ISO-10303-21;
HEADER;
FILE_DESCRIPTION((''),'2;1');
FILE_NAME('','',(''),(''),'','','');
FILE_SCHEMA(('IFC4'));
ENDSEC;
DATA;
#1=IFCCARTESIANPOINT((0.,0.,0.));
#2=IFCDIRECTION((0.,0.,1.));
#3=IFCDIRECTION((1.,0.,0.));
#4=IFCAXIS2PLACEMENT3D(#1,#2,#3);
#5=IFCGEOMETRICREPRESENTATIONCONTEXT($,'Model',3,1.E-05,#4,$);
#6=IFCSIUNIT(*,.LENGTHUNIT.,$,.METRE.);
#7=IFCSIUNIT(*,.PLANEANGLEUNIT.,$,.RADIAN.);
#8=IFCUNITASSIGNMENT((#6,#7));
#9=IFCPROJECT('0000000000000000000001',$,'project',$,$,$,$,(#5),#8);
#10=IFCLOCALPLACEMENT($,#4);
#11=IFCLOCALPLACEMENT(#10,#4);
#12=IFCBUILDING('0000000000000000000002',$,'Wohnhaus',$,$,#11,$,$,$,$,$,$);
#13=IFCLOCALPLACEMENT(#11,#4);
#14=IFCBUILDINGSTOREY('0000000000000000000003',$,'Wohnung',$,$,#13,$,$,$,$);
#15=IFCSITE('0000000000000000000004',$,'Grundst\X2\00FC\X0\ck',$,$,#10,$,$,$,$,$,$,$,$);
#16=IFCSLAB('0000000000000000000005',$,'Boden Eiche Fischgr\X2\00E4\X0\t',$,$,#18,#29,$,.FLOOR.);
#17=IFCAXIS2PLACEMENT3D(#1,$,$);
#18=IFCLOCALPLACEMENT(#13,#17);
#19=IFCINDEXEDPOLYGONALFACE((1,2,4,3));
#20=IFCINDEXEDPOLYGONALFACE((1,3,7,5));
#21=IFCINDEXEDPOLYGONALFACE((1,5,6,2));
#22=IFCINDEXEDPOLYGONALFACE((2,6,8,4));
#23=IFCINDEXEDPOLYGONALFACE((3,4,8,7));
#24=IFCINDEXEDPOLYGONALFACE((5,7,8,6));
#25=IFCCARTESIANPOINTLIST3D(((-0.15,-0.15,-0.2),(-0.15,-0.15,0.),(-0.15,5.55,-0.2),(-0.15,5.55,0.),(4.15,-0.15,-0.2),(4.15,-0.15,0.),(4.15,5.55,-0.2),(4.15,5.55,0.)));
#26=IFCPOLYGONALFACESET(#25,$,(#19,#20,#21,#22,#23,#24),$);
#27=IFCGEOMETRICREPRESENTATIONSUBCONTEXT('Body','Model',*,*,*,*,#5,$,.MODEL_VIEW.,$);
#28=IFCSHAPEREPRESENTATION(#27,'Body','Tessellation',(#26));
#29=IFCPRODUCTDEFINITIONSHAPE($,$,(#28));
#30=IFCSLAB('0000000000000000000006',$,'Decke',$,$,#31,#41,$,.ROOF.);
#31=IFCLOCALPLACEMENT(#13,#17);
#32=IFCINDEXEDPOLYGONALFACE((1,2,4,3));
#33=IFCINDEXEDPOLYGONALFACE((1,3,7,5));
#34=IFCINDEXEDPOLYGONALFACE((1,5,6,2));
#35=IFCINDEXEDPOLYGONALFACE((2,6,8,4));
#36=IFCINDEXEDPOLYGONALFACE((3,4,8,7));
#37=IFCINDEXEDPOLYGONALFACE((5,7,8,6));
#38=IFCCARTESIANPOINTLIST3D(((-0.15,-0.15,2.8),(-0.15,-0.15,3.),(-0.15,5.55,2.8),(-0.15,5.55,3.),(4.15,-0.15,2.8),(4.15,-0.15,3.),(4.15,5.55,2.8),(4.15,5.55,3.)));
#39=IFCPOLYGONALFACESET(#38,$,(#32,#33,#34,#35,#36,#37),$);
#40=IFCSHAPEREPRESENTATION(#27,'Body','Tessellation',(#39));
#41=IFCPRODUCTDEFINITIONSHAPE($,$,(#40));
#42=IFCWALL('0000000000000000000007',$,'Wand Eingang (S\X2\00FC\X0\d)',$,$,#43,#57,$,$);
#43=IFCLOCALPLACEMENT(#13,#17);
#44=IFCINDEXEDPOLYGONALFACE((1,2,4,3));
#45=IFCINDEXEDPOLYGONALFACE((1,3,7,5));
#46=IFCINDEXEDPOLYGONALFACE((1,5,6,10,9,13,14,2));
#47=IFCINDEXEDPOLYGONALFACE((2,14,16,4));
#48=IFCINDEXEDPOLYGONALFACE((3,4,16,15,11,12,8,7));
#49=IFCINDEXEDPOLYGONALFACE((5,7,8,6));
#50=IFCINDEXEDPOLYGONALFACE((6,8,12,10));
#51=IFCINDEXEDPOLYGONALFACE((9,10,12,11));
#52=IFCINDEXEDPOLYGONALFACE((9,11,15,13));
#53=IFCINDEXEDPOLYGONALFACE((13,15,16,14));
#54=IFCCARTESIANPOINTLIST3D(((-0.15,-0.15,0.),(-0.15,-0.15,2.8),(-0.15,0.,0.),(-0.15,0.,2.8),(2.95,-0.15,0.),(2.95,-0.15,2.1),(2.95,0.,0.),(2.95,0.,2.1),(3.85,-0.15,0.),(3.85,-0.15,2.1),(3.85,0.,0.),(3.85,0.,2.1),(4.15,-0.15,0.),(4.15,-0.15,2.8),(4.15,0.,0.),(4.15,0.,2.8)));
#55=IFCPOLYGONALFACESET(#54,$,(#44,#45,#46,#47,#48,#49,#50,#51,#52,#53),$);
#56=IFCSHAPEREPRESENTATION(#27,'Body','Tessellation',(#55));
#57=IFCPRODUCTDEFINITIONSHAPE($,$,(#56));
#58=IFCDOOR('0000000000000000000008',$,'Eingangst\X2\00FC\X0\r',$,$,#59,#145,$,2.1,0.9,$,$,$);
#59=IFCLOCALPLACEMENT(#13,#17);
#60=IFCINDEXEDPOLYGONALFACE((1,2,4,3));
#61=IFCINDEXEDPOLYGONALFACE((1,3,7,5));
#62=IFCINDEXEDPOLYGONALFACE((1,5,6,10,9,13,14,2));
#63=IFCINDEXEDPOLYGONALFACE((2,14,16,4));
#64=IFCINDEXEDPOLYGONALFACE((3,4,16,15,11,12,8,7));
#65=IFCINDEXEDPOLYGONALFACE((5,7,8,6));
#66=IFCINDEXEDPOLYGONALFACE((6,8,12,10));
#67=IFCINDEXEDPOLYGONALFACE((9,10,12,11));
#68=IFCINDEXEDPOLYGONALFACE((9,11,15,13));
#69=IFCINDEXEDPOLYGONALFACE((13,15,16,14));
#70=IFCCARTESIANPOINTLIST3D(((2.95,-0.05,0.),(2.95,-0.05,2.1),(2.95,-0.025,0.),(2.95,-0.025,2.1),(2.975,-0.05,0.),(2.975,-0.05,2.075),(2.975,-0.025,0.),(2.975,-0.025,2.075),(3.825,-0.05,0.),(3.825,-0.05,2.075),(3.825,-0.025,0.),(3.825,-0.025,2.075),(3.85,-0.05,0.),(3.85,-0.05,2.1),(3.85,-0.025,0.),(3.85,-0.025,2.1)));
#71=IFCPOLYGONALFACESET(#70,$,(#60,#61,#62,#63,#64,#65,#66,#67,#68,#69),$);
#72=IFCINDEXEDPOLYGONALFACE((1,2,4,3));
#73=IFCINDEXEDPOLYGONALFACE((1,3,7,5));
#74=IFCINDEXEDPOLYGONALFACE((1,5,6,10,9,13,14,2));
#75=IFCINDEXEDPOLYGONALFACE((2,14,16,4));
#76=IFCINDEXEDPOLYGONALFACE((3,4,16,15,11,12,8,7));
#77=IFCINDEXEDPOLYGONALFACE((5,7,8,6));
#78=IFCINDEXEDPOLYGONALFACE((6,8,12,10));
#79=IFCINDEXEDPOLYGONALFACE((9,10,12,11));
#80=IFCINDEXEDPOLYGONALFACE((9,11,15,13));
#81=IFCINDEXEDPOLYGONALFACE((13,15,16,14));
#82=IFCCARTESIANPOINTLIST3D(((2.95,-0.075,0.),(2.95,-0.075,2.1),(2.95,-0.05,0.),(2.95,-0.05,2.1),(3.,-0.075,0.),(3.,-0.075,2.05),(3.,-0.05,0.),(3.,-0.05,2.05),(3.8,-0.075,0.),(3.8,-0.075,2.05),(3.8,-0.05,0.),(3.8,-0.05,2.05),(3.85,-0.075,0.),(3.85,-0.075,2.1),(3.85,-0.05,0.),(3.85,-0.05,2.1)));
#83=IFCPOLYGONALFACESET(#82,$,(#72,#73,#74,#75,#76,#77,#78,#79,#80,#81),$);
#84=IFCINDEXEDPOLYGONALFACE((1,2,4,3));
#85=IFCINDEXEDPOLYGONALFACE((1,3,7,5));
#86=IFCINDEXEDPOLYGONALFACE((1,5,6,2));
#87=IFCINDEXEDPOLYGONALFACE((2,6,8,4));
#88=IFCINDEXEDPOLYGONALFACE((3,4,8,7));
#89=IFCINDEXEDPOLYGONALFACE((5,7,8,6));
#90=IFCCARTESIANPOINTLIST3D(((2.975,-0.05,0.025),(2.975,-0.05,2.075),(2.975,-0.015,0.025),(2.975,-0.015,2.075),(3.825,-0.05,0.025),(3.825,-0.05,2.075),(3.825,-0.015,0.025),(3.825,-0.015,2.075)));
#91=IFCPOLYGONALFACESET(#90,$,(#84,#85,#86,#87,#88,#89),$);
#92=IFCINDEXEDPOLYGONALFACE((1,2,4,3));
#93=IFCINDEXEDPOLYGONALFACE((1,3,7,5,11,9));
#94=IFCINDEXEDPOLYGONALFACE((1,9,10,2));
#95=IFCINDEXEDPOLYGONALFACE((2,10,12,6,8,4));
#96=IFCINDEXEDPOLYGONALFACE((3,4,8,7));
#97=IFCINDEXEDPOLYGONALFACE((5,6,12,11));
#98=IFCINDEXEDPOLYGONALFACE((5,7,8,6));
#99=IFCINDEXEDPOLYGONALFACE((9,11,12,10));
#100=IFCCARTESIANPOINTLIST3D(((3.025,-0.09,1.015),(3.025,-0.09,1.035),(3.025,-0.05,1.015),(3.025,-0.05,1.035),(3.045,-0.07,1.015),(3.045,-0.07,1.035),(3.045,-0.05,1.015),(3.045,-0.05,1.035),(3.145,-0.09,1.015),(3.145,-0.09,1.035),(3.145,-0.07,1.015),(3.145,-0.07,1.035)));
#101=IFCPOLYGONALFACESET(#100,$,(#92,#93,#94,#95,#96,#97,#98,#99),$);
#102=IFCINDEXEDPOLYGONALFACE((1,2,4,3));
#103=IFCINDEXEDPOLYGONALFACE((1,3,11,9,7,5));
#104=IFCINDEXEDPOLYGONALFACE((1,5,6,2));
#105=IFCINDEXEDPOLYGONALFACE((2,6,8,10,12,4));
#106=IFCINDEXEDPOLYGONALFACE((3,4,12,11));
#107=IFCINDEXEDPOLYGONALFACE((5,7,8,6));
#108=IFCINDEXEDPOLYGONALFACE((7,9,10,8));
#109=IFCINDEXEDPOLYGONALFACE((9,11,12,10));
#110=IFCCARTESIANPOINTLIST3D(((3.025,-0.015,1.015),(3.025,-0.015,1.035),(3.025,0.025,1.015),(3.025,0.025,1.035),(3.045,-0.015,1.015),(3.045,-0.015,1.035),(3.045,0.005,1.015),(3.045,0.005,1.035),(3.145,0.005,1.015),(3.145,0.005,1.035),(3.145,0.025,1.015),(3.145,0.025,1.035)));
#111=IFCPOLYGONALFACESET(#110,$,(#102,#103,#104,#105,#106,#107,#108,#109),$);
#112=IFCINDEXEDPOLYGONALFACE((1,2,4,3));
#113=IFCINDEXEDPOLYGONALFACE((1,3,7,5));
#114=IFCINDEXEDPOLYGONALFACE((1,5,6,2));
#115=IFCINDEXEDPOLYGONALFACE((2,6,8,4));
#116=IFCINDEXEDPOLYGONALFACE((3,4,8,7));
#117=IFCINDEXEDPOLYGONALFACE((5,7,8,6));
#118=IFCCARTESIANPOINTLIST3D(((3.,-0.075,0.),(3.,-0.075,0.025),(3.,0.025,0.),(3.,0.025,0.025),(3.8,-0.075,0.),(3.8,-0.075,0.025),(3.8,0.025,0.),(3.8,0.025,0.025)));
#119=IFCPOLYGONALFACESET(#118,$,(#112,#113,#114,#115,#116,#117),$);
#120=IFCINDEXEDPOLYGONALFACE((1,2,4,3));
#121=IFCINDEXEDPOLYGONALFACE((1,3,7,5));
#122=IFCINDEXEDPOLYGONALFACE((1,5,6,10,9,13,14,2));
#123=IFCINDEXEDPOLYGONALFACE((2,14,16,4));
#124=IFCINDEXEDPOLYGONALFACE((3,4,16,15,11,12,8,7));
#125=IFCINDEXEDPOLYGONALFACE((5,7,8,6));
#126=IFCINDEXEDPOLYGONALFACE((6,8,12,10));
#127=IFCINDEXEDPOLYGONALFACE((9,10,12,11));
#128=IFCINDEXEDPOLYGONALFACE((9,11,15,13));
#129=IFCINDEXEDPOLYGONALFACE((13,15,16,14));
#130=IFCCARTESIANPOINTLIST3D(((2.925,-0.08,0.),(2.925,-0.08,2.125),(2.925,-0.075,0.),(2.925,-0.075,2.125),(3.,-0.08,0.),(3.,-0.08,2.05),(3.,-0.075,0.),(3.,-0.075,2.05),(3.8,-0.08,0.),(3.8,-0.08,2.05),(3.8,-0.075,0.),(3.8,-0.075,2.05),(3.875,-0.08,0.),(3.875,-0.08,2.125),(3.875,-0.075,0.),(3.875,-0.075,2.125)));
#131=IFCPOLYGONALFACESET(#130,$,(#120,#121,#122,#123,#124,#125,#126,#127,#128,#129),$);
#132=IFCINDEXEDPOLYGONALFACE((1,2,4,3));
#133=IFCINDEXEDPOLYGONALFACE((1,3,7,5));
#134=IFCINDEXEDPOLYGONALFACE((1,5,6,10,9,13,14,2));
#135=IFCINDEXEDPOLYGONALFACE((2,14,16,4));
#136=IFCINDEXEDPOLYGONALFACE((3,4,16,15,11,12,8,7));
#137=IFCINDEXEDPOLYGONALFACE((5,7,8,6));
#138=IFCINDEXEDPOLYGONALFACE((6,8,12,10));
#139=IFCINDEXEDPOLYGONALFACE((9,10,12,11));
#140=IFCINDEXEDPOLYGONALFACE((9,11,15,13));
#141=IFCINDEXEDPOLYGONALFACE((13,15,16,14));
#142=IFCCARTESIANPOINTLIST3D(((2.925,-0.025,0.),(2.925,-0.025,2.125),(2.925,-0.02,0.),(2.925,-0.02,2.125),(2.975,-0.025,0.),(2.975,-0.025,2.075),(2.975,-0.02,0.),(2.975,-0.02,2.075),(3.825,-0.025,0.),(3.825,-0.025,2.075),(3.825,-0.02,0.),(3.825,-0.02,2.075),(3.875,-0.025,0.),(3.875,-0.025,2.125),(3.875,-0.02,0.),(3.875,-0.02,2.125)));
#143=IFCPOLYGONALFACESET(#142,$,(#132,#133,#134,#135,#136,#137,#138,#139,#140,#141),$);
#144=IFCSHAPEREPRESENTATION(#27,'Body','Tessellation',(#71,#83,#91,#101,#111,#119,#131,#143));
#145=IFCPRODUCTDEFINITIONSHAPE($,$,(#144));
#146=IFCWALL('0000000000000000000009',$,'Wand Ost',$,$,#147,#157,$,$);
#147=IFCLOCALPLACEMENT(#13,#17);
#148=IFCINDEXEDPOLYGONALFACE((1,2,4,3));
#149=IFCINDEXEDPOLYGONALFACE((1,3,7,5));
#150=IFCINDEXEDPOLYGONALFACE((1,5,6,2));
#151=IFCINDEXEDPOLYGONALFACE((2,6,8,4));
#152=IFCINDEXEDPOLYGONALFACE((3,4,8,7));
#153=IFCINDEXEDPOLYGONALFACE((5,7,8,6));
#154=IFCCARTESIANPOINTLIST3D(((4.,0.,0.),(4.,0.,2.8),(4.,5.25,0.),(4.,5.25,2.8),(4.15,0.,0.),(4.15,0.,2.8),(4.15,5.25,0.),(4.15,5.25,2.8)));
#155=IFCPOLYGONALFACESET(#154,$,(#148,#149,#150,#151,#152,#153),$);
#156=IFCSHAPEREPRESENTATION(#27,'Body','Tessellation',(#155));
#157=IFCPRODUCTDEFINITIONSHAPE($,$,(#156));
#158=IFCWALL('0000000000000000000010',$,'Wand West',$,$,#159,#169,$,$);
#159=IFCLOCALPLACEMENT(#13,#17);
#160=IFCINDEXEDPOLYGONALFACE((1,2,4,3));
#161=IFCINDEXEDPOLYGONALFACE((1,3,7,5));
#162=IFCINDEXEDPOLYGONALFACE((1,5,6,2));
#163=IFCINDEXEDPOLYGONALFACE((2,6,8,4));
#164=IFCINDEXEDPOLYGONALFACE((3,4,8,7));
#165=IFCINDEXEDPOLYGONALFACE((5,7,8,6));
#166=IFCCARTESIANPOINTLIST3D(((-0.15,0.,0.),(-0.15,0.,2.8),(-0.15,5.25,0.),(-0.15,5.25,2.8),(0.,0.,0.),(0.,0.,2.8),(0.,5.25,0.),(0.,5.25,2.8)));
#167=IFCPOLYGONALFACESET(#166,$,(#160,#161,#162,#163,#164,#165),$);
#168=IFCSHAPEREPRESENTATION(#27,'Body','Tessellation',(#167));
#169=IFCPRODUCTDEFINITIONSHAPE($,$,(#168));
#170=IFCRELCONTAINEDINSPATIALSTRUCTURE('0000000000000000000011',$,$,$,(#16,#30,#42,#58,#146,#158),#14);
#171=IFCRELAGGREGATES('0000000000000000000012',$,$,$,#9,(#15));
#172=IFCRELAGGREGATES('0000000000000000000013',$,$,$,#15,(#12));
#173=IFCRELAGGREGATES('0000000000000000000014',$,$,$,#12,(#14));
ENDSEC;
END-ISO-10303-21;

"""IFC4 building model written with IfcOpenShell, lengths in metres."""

from ifc_helpers import new_model, si_unit, frame, origin_with_axes, place, context, subcontext, project, spatial, line, indexed_curve, outline, extrude, element, fill, save


model = new_model("IFC4")

# Units and contexts
model_context = context("Model", 3, precision=1e-05, world=origin_with_axes())
body_context = subcontext(model_context, "Body", "Model", "MODEL_VIEW")
ifc_project = project(units=[si_unit("LENGTHUNIT", "METRE"), si_unit("PLANEANGLEUNIT", "RADIAN")], contexts=[model_context])

# Site, building, storey
site_placement = place(None, origin_with_axes())
site = spatial("IfcSite", under=ifc_project, at=site_placement, Name="Grundstück")
building_placement = place(site_placement, origin_with_axes())
building = spatial("IfcBuilding", under=site, at=building_placement, Name="Wohnhaus")
storey_placement = place(building_placement, origin_with_axes())
storey = spatial("IfcBuildingStorey", under=building, at=storey_placement, Name="Wohnung")

# Slabs
slab_1_placement = place(storey_placement, frame((0.0, 0.0, -0.2), z_axis=(0.0, 0.0, 1.0), x_axis=(1.0, 0.0, 0.0)))
element("IfcSlab", 1, at=slab_1_placement, inside=storey, Name="Boden Eiche Fischgrät", PredefinedType="FLOOR", context=body_context, shape_type="SweptSolid", body=[
    extrude(outline(indexed_curve([(-0.15, -0.15), (4.15, -0.15), (4.15, 5.55), (-0.15, 5.55)])), None, (0.0, 0.0, 1.0), 0.2),
])
slab_2_placement = place(storey_placement, frame((0.0, 0.0, 2.8), z_axis=(0.0, 0.0, 1.0), x_axis=(1.0, 0.0, 0.0)))
element("IfcSlab", 2, at=slab_2_placement, inside=storey, Name="Decke", PredefinedType="ROOF", context=body_context, shape_type="SweptSolid", body=[
    extrude(outline(indexed_curve([(-0.15, -0.15), (4.15, -0.15), (4.15, 5.55), (-0.15, 5.55)])), None, (0.0, 0.0, 1.0), 0.2),
])

# Wall, opening, door
wall_1_placement = place(storey_placement, frame((-0.15, -0.15, 0.0), z_axis=(0.0, 0.0, 1.0), x_axis=(1.0, 0.0, 0.0)))
wall_1 = element("IfcWall", 3, at=wall_1_placement, inside=storey, Name="Wand Eingang (Süd)", context=body_context, shape_type="SweptSolid", body=[
    extrude(outline(indexed_curve([(0.0, 0.0), (0.0, 0.15), (4.3, 0.15), (4.3, 0.0), (0.0, 0.0)], self_intersect=False)), origin_with_axes(), (0.0, 0.0, 1.0), 2.8),
])
opening_1_placement = place(wall_1_placement, frame((3.1, -0.1, 0.0), z_axis=(0.0, 0.0, 1.0), x_axis=(1.0, 0.0, 0.0)))
opening_1 = element("IfcOpeningElement", 4, at=opening_1_placement, cuts=wall_1, context=body_context, shape_type="SweptSolid", body=[
    extrude(outline(indexed_curve([(0.0, 0.0), (0.0, 0.35), (0.9, 0.35), (0.9, 0.0), (0.0, 0.0)], self_intersect=False)), origin_with_axes(), (0.0, 0.0, 1.0), 2.1),
])
door_placement = place(storey_placement, frame((2.95, -0.075, 0.0), z_axis=(0.0, 0.0, 1.0), x_axis=(1.0, 0.0, 0.0)))
door = element("IfcDoor", 5, at=door_placement, inside=storey, Name="Eingangstür", OverallHeight=2.1, OverallWidth=0.9, context=body_context, shape_type="SweptSolid", body=[
    extrude(outline(indexed_curve([(0.0, 0.0), (0.0, 2.1), (0.9, 2.1), (0.9, 0.0), (0.875, 0.0), (0.875, 2.075), (0.025, 2.075), (0.025, 0.0)], segments=[line(1, 2, 3, 4, 5, 6, 7, 8, 1)])), frame((0.0, 0.025, 0.0), z_axis=(0.0, -1.0, 0.0), x_axis=(1.0, 0.0, 0.0)), (0.0, 0.0, -1.0), 0.025),
    extrude(outline(indexed_curve([(0.0, 0.0), (0.0, 2.1), (0.9, 2.1), (0.9, 0.0), (0.85, 0.0), (0.85, 2.05), (0.05, 2.05), (0.05, 0.0)], segments=[line(1, 2, 3, 4, 5, 6, 7, 8, 1)])), frame((0.0, 0.0, 0.0), z_axis=(0.0, -1.0, 0.0), x_axis=(1.0, 0.0, 0.0)), (0.0, 0.0, -1.0), 0.025),
    extrude(outline(indexed_curve([(0.0, 0.0), (0.85, 0.0), (0.85, 0.035), (0.0, 0.035)], segments=[line(1, 2, 3, 4, 1)])), frame((0.025, 0.025, 0.025), z_axis=(0.0, 0.0, 1.0), x_axis=(1.0, 0.0, 0.0)), (0.0, 0.0, 1.0), 2.05),
    extrude(outline(indexed_curve([(0.0, 0.0), (0.0, -0.04), (0.12, -0.04), (0.12, -0.02), (0.02, -0.02), (0.02, 0.0)], segments=[line(1, 2, 3, 4, 5, 6, 1)])), frame((0.075, 0.025, 1.015), z_axis=(0.0, 0.0, 1.0), x_axis=(1.0, 0.0, 0.0)), (0.0, 0.0, 1.0), 0.02),
    extrude(outline(indexed_curve([(0.0, 0.0), (0.0, 0.04), (0.12, 0.04), (0.12, 0.02), (0.02, 0.02), (0.02, 0.0)], segments=[line(1, 2, 3, 4, 5, 6, 1)])), frame((0.075, 0.06, 1.015), z_axis=(0.0, 0.0, 1.0), x_axis=(1.0, 0.0, 0.0)), (0.0, 0.0, 1.0), 0.02),
    extrude(outline(indexed_curve([(0.0, 0.0), (0.8, 0.0), (0.8, 0.1), (0.0, 0.1)], segments=[line(1, 2, 3, 4, 1)])), frame((0.05, 0.0, 0.0), z_axis=(0.0, 0.0, 1.0), x_axis=(1.0, 0.0, 0.0)), (0.0, 0.0, 1.0), 0.025),
    extrude(outline(indexed_curve([(0.0, 0.0), (0.0, 2.125), (0.95, 2.125), (0.95, 0.0), (0.875, 0.0), (0.875, 2.05), (0.075, 2.05), (0.075, 0.0)], segments=[line(1, 2, 3, 4, 5, 6, 7, 8, 1)])), frame((-0.025, -0.005, 0.0), z_axis=(0.0, -1.0, 0.0), x_axis=(1.0, 0.0, 0.0)), (0.0, 0.0, -1.0), 0.005),
    extrude(outline(indexed_curve([(0.0, 0.0), (0.0, 2.125), (0.95, 2.125), (0.95, 0.0), (0.9, 0.0), (0.9, 2.075), (0.05, 2.075), (0.05, 0.0)], segments=[line(1, 2, 3, 4, 5, 6, 7, 8, 1)])), frame((-0.025, 0.05, 0.0), z_axis=(0.0, -1.0, 0.0), x_axis=(1.0, 0.0, 0.0)), (0.0, 0.0, -1.0), 0.005),
])
fill(opening_1, door)

# Walls
for number, where, z_axis, x_axis, name in (
    (6, (4.15, 0.0, 0.0), (0.0, 0.0, 1.0), (0.0, 1.0, 0.0), "Wand Ost"),
    (7, (-0.15, 5.25, 0.0), (0.0, 0.0, 1.0), (0.0, -1.0, 0.0), "Wand West"),
):
    element("IfcWall", number, at=place(storey_placement, frame(where, z_axis=z_axis, x_axis=x_axis)), inside=storey, Name=name, context=body_context, shape_type="SweptSolid", body=[
        extrude(outline(indexed_curve([(0.0, 0.0), (0.0, 0.15), (5.25, 0.15), (5.25, 0.0), (0.0, 0.0)], self_intersect=False)), origin_with_axes(), (0.0, 0.0, 1.0), 2.8),
    ])

save(model, "model.ifc")
